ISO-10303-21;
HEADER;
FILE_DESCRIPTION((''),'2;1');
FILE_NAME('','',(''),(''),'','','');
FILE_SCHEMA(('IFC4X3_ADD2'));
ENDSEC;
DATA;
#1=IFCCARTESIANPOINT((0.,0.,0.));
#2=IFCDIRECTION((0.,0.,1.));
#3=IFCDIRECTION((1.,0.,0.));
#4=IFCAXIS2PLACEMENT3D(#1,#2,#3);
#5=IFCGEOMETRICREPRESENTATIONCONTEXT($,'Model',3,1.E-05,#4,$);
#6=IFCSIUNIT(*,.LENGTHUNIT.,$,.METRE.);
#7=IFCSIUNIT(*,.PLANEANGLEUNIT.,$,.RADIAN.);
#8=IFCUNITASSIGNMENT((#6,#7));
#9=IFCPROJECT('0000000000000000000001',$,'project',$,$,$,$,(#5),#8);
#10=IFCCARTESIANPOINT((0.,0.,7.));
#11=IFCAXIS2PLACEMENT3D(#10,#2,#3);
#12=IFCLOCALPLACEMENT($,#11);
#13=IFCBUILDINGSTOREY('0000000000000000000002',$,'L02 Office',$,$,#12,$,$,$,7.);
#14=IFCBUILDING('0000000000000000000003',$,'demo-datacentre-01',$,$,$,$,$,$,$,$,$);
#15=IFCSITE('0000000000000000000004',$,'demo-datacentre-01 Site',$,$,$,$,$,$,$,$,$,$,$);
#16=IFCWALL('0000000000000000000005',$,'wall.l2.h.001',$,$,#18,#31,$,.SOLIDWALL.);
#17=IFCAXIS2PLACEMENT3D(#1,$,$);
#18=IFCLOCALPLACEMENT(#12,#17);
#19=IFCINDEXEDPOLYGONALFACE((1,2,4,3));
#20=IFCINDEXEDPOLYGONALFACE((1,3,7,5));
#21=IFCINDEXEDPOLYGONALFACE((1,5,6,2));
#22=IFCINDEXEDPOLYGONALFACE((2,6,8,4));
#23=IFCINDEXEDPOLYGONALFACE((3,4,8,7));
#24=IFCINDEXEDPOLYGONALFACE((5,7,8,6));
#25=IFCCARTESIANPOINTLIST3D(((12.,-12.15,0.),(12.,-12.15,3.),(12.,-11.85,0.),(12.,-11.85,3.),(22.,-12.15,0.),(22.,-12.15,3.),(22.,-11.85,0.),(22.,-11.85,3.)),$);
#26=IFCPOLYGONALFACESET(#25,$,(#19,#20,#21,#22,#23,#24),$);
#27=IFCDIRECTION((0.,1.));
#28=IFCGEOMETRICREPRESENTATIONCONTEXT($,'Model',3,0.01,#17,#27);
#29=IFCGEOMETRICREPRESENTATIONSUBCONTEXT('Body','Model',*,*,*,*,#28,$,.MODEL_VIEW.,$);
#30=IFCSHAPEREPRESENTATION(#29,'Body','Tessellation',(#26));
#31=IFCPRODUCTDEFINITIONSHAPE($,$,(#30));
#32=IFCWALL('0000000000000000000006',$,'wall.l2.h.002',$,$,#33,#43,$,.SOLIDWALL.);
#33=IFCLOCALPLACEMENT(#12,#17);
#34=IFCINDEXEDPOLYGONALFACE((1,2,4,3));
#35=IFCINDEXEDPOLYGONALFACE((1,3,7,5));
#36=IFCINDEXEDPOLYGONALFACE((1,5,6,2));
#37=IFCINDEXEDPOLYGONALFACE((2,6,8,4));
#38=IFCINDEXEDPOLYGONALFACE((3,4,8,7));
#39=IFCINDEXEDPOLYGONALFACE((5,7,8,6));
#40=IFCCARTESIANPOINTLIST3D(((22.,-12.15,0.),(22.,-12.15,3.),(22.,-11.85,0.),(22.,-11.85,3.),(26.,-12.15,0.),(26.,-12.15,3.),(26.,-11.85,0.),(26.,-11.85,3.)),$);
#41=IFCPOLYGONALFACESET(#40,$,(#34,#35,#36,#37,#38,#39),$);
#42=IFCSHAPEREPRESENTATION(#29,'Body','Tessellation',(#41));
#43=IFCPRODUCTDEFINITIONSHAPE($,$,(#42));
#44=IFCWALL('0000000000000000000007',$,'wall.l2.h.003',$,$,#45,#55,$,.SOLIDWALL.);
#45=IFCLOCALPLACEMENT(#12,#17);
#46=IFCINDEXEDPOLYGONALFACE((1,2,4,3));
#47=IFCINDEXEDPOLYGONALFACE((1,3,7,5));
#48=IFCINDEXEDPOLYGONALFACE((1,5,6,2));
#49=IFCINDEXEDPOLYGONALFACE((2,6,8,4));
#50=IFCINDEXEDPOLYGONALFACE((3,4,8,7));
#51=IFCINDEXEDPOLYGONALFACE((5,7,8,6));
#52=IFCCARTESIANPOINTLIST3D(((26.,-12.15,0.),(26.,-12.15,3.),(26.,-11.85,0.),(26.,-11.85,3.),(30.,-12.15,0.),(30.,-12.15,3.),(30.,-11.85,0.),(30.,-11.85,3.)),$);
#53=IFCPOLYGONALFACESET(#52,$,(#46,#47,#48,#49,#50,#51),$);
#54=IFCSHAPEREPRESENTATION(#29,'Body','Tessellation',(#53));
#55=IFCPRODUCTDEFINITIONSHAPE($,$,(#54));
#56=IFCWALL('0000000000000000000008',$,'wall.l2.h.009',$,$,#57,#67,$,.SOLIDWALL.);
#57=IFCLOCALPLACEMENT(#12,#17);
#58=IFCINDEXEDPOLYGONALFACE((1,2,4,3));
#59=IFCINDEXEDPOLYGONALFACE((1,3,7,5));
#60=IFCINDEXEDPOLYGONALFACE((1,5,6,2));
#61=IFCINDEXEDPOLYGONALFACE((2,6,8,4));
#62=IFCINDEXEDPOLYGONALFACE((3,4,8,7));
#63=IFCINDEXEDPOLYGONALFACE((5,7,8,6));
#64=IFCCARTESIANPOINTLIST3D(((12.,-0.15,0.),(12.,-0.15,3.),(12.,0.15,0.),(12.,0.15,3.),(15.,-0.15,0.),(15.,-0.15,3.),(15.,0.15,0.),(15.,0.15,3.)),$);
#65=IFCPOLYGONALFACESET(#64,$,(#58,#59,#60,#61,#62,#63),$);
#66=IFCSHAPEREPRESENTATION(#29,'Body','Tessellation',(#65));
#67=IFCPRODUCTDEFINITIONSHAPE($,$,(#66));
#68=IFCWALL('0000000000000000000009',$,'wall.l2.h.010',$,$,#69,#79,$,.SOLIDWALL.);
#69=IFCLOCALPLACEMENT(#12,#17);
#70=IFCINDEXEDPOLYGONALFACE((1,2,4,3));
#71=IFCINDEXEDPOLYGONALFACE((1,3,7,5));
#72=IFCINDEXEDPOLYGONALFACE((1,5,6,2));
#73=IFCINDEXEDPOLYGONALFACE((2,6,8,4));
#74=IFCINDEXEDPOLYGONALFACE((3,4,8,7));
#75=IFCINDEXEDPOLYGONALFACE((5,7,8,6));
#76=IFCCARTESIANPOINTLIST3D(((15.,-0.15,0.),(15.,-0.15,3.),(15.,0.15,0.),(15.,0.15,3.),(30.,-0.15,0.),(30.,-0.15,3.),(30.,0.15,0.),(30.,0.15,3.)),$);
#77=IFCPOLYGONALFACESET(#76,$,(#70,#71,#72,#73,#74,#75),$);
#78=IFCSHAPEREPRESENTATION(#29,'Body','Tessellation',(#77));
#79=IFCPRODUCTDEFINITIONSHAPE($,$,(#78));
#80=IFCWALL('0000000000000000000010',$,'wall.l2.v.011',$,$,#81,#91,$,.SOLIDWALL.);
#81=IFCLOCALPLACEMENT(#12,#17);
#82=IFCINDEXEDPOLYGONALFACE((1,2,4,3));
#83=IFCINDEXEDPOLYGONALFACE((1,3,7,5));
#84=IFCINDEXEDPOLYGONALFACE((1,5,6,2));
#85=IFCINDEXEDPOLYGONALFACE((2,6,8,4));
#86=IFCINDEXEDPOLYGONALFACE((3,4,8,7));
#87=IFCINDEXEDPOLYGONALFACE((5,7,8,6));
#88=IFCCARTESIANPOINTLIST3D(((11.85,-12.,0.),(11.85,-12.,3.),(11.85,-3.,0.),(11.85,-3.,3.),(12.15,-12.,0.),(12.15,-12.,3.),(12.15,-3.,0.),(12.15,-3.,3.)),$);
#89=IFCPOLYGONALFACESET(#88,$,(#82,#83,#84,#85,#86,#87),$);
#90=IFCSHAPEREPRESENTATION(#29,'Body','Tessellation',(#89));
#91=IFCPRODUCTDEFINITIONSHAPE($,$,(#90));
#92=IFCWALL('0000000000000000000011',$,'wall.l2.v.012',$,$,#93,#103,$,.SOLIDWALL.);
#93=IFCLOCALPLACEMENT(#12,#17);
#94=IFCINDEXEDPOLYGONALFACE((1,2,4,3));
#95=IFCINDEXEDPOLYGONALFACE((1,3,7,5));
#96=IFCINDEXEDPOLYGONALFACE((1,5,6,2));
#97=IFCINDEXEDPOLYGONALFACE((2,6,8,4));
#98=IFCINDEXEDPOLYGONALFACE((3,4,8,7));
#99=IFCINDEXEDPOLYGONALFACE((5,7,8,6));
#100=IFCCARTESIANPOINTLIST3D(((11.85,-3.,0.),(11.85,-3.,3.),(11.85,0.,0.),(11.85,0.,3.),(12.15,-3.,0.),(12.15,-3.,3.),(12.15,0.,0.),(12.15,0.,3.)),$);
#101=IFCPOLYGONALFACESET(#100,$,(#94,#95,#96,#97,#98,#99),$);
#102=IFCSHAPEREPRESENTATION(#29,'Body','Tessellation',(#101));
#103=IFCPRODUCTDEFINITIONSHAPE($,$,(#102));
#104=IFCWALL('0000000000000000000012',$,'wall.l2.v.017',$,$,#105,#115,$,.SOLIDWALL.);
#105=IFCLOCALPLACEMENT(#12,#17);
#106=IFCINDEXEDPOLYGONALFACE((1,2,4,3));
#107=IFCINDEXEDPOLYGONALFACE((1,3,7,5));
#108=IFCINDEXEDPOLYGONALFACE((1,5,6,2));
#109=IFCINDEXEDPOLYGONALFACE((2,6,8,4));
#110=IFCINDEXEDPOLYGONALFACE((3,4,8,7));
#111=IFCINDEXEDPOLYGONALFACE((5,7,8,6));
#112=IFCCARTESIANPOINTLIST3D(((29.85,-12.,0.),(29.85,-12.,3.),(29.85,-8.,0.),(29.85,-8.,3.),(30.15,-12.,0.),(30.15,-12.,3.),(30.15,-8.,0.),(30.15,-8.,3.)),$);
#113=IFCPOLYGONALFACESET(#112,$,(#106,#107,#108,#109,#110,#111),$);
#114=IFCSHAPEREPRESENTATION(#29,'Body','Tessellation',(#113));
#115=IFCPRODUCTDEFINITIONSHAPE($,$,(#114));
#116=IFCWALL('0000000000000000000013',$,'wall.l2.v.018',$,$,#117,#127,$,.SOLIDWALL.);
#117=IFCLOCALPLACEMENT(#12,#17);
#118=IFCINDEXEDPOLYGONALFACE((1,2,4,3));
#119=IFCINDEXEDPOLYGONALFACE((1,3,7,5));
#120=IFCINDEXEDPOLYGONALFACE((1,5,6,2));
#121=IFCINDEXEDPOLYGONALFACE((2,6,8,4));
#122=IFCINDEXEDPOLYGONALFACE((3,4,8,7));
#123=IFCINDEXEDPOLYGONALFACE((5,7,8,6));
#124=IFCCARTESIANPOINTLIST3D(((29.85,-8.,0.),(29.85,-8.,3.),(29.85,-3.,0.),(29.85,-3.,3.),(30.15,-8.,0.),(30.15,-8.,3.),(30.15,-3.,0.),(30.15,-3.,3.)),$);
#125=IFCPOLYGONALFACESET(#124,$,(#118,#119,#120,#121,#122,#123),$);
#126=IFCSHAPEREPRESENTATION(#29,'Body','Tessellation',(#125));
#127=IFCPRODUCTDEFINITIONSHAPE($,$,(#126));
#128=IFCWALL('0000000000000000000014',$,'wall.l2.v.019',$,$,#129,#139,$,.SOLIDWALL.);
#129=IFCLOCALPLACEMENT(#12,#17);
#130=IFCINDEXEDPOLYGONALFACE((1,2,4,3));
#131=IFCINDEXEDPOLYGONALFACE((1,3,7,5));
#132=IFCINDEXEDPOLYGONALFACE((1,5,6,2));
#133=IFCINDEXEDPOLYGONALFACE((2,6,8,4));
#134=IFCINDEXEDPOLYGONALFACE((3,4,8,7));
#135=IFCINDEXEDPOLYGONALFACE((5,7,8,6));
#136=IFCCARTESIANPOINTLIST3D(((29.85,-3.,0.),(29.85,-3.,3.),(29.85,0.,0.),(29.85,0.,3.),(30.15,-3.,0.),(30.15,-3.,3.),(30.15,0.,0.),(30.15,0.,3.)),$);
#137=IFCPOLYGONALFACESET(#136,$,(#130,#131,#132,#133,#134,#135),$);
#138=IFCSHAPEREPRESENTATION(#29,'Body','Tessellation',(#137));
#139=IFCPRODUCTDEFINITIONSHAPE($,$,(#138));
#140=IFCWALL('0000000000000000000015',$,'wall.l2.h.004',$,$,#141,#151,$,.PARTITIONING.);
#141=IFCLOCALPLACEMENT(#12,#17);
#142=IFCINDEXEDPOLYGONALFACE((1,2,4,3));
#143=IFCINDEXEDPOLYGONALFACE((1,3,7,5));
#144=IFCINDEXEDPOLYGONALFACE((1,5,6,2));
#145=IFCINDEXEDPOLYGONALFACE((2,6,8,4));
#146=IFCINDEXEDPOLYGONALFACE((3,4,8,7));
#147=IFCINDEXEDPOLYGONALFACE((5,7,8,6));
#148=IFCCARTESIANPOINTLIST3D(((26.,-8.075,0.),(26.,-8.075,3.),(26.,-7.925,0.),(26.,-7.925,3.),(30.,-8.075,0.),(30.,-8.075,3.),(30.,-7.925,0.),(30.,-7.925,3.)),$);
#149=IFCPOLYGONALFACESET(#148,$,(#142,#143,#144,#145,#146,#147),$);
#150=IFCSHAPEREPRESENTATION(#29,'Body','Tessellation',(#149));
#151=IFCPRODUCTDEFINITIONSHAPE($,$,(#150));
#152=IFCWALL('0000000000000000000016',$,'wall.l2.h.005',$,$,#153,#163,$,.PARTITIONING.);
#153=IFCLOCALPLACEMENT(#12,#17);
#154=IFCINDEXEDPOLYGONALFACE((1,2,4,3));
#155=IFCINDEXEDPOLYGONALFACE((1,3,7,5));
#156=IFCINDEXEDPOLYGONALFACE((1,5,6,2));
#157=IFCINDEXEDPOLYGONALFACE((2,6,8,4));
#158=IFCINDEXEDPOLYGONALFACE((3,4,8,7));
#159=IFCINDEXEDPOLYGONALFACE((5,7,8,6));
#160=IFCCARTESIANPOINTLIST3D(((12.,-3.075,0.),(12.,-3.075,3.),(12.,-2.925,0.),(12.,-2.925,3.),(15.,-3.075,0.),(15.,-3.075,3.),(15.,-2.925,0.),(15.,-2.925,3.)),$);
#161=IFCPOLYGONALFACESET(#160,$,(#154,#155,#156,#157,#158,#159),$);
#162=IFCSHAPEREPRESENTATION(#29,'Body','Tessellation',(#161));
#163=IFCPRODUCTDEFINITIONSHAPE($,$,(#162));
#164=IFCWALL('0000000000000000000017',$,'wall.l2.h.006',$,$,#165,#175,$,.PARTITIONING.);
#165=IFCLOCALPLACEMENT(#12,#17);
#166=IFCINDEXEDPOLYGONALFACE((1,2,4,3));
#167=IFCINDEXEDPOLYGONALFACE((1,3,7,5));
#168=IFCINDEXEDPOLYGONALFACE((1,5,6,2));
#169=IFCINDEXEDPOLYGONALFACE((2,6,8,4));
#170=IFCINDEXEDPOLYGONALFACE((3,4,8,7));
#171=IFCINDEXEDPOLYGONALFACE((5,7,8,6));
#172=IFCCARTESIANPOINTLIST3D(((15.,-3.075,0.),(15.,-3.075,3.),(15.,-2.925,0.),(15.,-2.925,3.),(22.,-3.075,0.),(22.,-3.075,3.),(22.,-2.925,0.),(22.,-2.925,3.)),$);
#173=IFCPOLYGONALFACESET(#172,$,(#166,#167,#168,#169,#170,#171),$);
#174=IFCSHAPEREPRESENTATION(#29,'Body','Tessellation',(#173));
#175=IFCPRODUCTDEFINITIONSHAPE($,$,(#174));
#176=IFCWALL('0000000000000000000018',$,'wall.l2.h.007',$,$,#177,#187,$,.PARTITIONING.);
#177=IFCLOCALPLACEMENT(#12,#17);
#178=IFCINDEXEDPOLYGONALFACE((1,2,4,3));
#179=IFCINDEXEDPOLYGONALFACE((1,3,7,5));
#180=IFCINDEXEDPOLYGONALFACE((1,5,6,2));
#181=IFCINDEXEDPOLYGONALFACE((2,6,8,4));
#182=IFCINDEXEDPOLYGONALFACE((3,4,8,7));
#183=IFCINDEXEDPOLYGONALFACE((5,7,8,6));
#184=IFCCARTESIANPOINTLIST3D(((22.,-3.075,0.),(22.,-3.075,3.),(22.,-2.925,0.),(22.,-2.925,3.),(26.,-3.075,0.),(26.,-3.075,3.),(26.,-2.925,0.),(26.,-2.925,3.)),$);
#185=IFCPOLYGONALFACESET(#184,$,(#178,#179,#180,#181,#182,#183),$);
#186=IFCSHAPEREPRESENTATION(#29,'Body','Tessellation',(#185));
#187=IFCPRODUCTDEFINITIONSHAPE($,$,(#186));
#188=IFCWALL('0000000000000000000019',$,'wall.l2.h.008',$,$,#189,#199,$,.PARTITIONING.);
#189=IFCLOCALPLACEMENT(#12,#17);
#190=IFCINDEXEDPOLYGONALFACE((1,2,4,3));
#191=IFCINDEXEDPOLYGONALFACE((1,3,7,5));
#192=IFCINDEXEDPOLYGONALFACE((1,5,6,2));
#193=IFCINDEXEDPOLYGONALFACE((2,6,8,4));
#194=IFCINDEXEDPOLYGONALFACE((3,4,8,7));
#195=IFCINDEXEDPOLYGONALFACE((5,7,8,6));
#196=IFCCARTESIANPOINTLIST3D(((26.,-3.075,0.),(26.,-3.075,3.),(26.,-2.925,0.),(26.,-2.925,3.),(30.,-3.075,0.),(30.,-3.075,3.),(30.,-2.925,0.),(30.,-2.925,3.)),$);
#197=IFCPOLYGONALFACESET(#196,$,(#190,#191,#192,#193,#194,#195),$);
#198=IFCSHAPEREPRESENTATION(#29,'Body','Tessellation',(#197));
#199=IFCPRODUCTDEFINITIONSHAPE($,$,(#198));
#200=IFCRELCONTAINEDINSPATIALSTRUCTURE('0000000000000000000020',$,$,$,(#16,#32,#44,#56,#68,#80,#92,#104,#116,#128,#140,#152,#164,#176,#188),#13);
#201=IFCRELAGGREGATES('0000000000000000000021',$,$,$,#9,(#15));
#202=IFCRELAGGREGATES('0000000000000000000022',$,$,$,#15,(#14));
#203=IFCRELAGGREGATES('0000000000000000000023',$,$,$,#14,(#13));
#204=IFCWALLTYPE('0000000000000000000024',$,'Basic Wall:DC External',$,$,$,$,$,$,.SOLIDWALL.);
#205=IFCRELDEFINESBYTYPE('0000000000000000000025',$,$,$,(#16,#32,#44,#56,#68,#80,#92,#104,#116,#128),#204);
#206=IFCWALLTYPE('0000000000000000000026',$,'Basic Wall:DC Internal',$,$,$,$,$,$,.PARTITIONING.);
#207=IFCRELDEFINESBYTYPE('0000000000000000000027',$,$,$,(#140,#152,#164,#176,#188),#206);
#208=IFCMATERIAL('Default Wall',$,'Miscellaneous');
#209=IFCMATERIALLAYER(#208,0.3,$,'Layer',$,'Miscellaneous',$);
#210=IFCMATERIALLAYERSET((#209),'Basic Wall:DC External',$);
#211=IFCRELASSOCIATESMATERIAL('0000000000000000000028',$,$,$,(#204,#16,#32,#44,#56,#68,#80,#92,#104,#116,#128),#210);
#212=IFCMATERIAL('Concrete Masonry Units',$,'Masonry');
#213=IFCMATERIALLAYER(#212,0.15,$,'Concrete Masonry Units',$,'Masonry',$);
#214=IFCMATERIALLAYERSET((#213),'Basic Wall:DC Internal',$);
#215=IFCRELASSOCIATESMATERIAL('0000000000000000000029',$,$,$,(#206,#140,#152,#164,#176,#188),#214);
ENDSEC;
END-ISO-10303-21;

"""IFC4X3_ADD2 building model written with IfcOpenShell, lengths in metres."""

from ifc_helpers import new_model, si_unit, direction, frame, frame_2d, origin, origin_with_axes, place, context, subcontext, project, spatial, rectangle, extrude, material, layer, layer_set, type_object, element, save


model = new_model("IFC4X3_ADD2")

# Units and contexts
model_context_1 = context("Model", 3, precision=0.01, world=origin(), true_north=direction((0.0, 1.0)))
model_context_2 = context("Model", 3, precision=1e-05, world=origin_with_axes())
body_context = subcontext(model_context_1, "Body", "Model", "MODEL_VIEW")
ifc_project = project(units=[si_unit("LENGTHUNIT", "METRE"), si_unit("PLANEANGLEUNIT", "RADIAN")], contexts=[model_context_2])

# Site, building, storey
site = spatial("IfcSite", under=ifc_project, Name="demo-datacentre-01 Site")
building = spatial("IfcBuilding", under=site, Name="demo-datacentre-01")
storey_placement = place(None, frame((0.0, 0.0, 7.0), z_axis=(0.0, 0.0, 1.0), x_axis=(1.0, 0.0, 0.0)))
storey = spatial("IfcBuildingStorey", under=building, at=storey_placement, Name="L02 Office", Elevation=7.0)

# Shared definitions
placement_1 = place(None, origin())
placement_2 = place(placement_1, origin())
placement_3 = place(placement_2, frame((0.0, 0.0, 7.0)))

# Walls
ifc_material_1 = material(Name="Default Wall", Category="Miscellaneous")
ifc_layer_1 = layer(ifc_material_1, 0.3, Name="Layer", Category="Miscellaneous")
ifc_layer_set_1 = layer_set([ifc_layer_1], Name="Basic Wall:DC External")
wall_type_1 = type_object("IfcWallType", Name="Basic Wall:DC External", PredefinedType="SOLIDWALL", material=ifc_layer_set_1)
wall_1_placement = place(placement_3, frame((12.0, -12.0, 0.0)))
element("IfcWall", 1, at=wall_1_placement, inside=storey, type_object=wall_type_1, material=ifc_layer_set_1, Name="wall.l2.h.001", PredefinedType="SOLIDWALL", context=body_context, shape_type="SweptSolid", body=[
    extrude(rectangle(XDim=10.0, YDim=0.3, at=frame_2d((5.0, 0.0), x_axis=(-1.0, 0.0))), origin(), (0.0, 0.0, 1.0), 3.0),
])
for number, where, name in (
    (2, (22.0, -12.0, 0.0), "wall.l2.h.002"),
    (3, (26.0, -12.0, 0.0), "wall.l2.h.003"),
):
    element("IfcWall", number, at=place(placement_3, frame(where)), inside=storey, type_object=wall_type_1, material=ifc_layer_set_1, Name=name, PredefinedType="SOLIDWALL", context=body_context, shape_type="SweptSolid", body=[
        extrude(rectangle(XDim=4.0, YDim=0.3, at=frame_2d((2.0, 0.0), x_axis=(-1.0, 0.0))), origin(), (0.0, 0.0, 1.0), 3.0),
    ])
wall_2_placement = place(placement_3, frame((12.0, 0.0, 0.0)))
element("IfcWall", 4, at=wall_2_placement, inside=storey, type_object=wall_type_1, material=ifc_layer_set_1, Name="wall.l2.h.009", PredefinedType="SOLIDWALL", context=body_context, shape_type="SweptSolid", body=[
    extrude(rectangle(XDim=3.0, YDim=0.3, at=frame_2d((1.5, 0.0), x_axis=(-1.0, 0.0))), origin(), (0.0, 0.0, 1.0), 3.0),
])
wall_3_placement = place(placement_3, frame((15.0, 0.0, 0.0)))
element("IfcWall", 5, at=wall_3_placement, inside=storey, type_object=wall_type_1, material=ifc_layer_set_1, Name="wall.l2.h.010", PredefinedType="SOLIDWALL", context=body_context, shape_type="SweptSolid", body=[
    extrude(rectangle(XDim=15.0, YDim=0.3, at=frame_2d((7.5, 0.0), x_axis=(-1.0, 0.0))), origin(), (0.0, 0.0, 1.0), 3.0),
])
wall_4_placement = place(placement_3, frame((12.0, -12.0, 0.0), z_axis=(0.0, 0.0, 1.0), x_axis=(0.0, 1.0, 0.0)))
element("IfcWall", 6, at=wall_4_placement, inside=storey, type_object=wall_type_1, material=ifc_layer_set_1, Name="wall.l2.v.011", PredefinedType="SOLIDWALL", context=body_context, shape_type="SweptSolid", body=[
    extrude(rectangle(XDim=9.0, YDim=0.3, at=frame_2d((4.5, 0.0), x_axis=(-1.0, 0.0))), origin(), (0.0, 0.0, 1.0), 3.0),
])
wall_5_placement = place(placement_3, frame((12.0, -3.0, 0.0), z_axis=(0.0, 0.0, 1.0), x_axis=(0.0, 1.0, 0.0)))
element("IfcWall", 7, at=wall_5_placement, inside=storey, type_object=wall_type_1, material=ifc_layer_set_1, Name="wall.l2.v.012", PredefinedType="SOLIDWALL", context=body_context, shape_type="SweptSolid", body=[
    extrude(rectangle(XDim=3.0, YDim=0.3, at=frame_2d((1.5, 0.0), x_axis=(-1.0, 0.0))), origin(), (0.0, 0.0, 1.0), 3.0),
])
wall_6_placement = place(placement_3, frame((30.0, -12.0, 0.0), z_axis=(0.0, 0.0, 1.0), x_axis=(0.0, 1.0, 0.0)))
element("IfcWall", 8, at=wall_6_placement, inside=storey, type_object=wall_type_1, material=ifc_layer_set_1, Name="wall.l2.v.017", PredefinedType="SOLIDWALL", context=body_context, shape_type="SweptSolid", body=[
    extrude(rectangle(XDim=4.0, YDim=0.3, at=frame_2d((2.0, 0.0), x_axis=(-1.0, 0.0))), origin(), (0.0, 0.0, 1.0), 3.0),
])
wall_7_placement = place(placement_3, frame((30.0, -8.0, 0.0), z_axis=(0.0, 0.0, 1.0), x_axis=(0.0, 1.0, 0.0)))
element("IfcWall", 9, at=wall_7_placement, inside=storey, type_object=wall_type_1, material=ifc_layer_set_1, Name="wall.l2.v.018", PredefinedType="SOLIDWALL", context=body_context, shape_type="SweptSolid", body=[
    extrude(rectangle(XDim=5.0, YDim=0.3, at=frame_2d((2.5, 0.0), x_axis=(-1.0, 0.0))), origin(), (0.0, 0.0, 1.0), 3.0),
])
wall_8_placement = place(placement_3, frame((30.0, -3.0, 0.0), z_axis=(0.0, 0.0, 1.0), x_axis=(0.0, 1.0, 0.0)))
element("IfcWall", 10, at=wall_8_placement, inside=storey, type_object=wall_type_1, material=ifc_layer_set_1, Name="wall.l2.v.019", PredefinedType="SOLIDWALL", context=body_context, shape_type="SweptSolid", body=[
    extrude(rectangle(XDim=3.0, YDim=0.3, at=frame_2d((1.5, 0.0), x_axis=(-1.0, 0.0))), origin(), (0.0, 0.0, 1.0), 3.0),
])
ifc_material_2 = material(Name="Concrete Masonry Units", Category="Masonry")
ifc_layer_2 = layer(ifc_material_2, 0.15, Name="Concrete Masonry Units", Category="Masonry")
ifc_layer_set_2 = layer_set([ifc_layer_2], Name="Basic Wall:DC Internal")
wall_type_2 = type_object("IfcWallType", Name="Basic Wall:DC Internal", PredefinedType="PARTITIONING", material=ifc_layer_set_2)
wall_9_placement = place(placement_3, frame((26.0, -8.0, 0.0)))
element("IfcWall", 11, at=wall_9_placement, inside=storey, type_object=wall_type_2, material=ifc_layer_set_2, Name="wall.l2.h.004", PredefinedType="PARTITIONING", context=body_context, shape_type="SweptSolid", body=[
    extrude(rectangle(XDim=4.0, YDim=0.15, at=frame_2d((2.0, 0.0), x_axis=(-1.0, 0.0))), origin(), (0.0, 0.0, 1.0), 3.0),
])
wall_10_placement = place(placement_3, frame((12.0, -3.0, 0.0)))
element("IfcWall", 12, at=wall_10_placement, inside=storey, type_object=wall_type_2, material=ifc_layer_set_2, Name="wall.l2.h.005", PredefinedType="PARTITIONING", context=body_context, shape_type="SweptSolid", body=[
    extrude(rectangle(XDim=3.0, YDim=0.15, at=frame_2d((1.5, 0.0), x_axis=(-1.0, 0.0))), origin(), (0.0, 0.0, 1.0), 3.0),
])
wall_11_placement = place(placement_3, frame((15.0, -3.0, 0.0)))
element("IfcWall", 13, at=wall_11_placement, inside=storey, type_object=wall_type_2, material=ifc_layer_set_2, Name="wall.l2.h.006", PredefinedType="PARTITIONING", context=body_context, shape_type="SweptSolid", body=[
    extrude(rectangle(XDim=7.0, YDim=0.15, at=frame_2d((3.5, 0.0), x_axis=(-1.0, 0.0))), origin(), (0.0, 0.0, 1.0), 3.0),
])
for number, where, name in (
    (14, (22.0, -3.0, 0.0), "wall.l2.h.007"),
    (15, (26.0, -3.0, 0.0), "wall.l2.h.008"),
):
    element("IfcWall", number, at=place(placement_3, frame(where)), inside=storey, type_object=wall_type_2, material=ifc_layer_set_2, Name=name, PredefinedType="PARTITIONING", context=body_context, shape_type="SweptSolid", body=[
        extrude(rectangle(XDim=4.0, YDim=0.15, at=frame_2d((2.0, 0.0), x_axis=(-1.0, 0.0))), origin(), (0.0, 0.0, 1.0), 3.0),
    ])

save(model, "model.ifc")
